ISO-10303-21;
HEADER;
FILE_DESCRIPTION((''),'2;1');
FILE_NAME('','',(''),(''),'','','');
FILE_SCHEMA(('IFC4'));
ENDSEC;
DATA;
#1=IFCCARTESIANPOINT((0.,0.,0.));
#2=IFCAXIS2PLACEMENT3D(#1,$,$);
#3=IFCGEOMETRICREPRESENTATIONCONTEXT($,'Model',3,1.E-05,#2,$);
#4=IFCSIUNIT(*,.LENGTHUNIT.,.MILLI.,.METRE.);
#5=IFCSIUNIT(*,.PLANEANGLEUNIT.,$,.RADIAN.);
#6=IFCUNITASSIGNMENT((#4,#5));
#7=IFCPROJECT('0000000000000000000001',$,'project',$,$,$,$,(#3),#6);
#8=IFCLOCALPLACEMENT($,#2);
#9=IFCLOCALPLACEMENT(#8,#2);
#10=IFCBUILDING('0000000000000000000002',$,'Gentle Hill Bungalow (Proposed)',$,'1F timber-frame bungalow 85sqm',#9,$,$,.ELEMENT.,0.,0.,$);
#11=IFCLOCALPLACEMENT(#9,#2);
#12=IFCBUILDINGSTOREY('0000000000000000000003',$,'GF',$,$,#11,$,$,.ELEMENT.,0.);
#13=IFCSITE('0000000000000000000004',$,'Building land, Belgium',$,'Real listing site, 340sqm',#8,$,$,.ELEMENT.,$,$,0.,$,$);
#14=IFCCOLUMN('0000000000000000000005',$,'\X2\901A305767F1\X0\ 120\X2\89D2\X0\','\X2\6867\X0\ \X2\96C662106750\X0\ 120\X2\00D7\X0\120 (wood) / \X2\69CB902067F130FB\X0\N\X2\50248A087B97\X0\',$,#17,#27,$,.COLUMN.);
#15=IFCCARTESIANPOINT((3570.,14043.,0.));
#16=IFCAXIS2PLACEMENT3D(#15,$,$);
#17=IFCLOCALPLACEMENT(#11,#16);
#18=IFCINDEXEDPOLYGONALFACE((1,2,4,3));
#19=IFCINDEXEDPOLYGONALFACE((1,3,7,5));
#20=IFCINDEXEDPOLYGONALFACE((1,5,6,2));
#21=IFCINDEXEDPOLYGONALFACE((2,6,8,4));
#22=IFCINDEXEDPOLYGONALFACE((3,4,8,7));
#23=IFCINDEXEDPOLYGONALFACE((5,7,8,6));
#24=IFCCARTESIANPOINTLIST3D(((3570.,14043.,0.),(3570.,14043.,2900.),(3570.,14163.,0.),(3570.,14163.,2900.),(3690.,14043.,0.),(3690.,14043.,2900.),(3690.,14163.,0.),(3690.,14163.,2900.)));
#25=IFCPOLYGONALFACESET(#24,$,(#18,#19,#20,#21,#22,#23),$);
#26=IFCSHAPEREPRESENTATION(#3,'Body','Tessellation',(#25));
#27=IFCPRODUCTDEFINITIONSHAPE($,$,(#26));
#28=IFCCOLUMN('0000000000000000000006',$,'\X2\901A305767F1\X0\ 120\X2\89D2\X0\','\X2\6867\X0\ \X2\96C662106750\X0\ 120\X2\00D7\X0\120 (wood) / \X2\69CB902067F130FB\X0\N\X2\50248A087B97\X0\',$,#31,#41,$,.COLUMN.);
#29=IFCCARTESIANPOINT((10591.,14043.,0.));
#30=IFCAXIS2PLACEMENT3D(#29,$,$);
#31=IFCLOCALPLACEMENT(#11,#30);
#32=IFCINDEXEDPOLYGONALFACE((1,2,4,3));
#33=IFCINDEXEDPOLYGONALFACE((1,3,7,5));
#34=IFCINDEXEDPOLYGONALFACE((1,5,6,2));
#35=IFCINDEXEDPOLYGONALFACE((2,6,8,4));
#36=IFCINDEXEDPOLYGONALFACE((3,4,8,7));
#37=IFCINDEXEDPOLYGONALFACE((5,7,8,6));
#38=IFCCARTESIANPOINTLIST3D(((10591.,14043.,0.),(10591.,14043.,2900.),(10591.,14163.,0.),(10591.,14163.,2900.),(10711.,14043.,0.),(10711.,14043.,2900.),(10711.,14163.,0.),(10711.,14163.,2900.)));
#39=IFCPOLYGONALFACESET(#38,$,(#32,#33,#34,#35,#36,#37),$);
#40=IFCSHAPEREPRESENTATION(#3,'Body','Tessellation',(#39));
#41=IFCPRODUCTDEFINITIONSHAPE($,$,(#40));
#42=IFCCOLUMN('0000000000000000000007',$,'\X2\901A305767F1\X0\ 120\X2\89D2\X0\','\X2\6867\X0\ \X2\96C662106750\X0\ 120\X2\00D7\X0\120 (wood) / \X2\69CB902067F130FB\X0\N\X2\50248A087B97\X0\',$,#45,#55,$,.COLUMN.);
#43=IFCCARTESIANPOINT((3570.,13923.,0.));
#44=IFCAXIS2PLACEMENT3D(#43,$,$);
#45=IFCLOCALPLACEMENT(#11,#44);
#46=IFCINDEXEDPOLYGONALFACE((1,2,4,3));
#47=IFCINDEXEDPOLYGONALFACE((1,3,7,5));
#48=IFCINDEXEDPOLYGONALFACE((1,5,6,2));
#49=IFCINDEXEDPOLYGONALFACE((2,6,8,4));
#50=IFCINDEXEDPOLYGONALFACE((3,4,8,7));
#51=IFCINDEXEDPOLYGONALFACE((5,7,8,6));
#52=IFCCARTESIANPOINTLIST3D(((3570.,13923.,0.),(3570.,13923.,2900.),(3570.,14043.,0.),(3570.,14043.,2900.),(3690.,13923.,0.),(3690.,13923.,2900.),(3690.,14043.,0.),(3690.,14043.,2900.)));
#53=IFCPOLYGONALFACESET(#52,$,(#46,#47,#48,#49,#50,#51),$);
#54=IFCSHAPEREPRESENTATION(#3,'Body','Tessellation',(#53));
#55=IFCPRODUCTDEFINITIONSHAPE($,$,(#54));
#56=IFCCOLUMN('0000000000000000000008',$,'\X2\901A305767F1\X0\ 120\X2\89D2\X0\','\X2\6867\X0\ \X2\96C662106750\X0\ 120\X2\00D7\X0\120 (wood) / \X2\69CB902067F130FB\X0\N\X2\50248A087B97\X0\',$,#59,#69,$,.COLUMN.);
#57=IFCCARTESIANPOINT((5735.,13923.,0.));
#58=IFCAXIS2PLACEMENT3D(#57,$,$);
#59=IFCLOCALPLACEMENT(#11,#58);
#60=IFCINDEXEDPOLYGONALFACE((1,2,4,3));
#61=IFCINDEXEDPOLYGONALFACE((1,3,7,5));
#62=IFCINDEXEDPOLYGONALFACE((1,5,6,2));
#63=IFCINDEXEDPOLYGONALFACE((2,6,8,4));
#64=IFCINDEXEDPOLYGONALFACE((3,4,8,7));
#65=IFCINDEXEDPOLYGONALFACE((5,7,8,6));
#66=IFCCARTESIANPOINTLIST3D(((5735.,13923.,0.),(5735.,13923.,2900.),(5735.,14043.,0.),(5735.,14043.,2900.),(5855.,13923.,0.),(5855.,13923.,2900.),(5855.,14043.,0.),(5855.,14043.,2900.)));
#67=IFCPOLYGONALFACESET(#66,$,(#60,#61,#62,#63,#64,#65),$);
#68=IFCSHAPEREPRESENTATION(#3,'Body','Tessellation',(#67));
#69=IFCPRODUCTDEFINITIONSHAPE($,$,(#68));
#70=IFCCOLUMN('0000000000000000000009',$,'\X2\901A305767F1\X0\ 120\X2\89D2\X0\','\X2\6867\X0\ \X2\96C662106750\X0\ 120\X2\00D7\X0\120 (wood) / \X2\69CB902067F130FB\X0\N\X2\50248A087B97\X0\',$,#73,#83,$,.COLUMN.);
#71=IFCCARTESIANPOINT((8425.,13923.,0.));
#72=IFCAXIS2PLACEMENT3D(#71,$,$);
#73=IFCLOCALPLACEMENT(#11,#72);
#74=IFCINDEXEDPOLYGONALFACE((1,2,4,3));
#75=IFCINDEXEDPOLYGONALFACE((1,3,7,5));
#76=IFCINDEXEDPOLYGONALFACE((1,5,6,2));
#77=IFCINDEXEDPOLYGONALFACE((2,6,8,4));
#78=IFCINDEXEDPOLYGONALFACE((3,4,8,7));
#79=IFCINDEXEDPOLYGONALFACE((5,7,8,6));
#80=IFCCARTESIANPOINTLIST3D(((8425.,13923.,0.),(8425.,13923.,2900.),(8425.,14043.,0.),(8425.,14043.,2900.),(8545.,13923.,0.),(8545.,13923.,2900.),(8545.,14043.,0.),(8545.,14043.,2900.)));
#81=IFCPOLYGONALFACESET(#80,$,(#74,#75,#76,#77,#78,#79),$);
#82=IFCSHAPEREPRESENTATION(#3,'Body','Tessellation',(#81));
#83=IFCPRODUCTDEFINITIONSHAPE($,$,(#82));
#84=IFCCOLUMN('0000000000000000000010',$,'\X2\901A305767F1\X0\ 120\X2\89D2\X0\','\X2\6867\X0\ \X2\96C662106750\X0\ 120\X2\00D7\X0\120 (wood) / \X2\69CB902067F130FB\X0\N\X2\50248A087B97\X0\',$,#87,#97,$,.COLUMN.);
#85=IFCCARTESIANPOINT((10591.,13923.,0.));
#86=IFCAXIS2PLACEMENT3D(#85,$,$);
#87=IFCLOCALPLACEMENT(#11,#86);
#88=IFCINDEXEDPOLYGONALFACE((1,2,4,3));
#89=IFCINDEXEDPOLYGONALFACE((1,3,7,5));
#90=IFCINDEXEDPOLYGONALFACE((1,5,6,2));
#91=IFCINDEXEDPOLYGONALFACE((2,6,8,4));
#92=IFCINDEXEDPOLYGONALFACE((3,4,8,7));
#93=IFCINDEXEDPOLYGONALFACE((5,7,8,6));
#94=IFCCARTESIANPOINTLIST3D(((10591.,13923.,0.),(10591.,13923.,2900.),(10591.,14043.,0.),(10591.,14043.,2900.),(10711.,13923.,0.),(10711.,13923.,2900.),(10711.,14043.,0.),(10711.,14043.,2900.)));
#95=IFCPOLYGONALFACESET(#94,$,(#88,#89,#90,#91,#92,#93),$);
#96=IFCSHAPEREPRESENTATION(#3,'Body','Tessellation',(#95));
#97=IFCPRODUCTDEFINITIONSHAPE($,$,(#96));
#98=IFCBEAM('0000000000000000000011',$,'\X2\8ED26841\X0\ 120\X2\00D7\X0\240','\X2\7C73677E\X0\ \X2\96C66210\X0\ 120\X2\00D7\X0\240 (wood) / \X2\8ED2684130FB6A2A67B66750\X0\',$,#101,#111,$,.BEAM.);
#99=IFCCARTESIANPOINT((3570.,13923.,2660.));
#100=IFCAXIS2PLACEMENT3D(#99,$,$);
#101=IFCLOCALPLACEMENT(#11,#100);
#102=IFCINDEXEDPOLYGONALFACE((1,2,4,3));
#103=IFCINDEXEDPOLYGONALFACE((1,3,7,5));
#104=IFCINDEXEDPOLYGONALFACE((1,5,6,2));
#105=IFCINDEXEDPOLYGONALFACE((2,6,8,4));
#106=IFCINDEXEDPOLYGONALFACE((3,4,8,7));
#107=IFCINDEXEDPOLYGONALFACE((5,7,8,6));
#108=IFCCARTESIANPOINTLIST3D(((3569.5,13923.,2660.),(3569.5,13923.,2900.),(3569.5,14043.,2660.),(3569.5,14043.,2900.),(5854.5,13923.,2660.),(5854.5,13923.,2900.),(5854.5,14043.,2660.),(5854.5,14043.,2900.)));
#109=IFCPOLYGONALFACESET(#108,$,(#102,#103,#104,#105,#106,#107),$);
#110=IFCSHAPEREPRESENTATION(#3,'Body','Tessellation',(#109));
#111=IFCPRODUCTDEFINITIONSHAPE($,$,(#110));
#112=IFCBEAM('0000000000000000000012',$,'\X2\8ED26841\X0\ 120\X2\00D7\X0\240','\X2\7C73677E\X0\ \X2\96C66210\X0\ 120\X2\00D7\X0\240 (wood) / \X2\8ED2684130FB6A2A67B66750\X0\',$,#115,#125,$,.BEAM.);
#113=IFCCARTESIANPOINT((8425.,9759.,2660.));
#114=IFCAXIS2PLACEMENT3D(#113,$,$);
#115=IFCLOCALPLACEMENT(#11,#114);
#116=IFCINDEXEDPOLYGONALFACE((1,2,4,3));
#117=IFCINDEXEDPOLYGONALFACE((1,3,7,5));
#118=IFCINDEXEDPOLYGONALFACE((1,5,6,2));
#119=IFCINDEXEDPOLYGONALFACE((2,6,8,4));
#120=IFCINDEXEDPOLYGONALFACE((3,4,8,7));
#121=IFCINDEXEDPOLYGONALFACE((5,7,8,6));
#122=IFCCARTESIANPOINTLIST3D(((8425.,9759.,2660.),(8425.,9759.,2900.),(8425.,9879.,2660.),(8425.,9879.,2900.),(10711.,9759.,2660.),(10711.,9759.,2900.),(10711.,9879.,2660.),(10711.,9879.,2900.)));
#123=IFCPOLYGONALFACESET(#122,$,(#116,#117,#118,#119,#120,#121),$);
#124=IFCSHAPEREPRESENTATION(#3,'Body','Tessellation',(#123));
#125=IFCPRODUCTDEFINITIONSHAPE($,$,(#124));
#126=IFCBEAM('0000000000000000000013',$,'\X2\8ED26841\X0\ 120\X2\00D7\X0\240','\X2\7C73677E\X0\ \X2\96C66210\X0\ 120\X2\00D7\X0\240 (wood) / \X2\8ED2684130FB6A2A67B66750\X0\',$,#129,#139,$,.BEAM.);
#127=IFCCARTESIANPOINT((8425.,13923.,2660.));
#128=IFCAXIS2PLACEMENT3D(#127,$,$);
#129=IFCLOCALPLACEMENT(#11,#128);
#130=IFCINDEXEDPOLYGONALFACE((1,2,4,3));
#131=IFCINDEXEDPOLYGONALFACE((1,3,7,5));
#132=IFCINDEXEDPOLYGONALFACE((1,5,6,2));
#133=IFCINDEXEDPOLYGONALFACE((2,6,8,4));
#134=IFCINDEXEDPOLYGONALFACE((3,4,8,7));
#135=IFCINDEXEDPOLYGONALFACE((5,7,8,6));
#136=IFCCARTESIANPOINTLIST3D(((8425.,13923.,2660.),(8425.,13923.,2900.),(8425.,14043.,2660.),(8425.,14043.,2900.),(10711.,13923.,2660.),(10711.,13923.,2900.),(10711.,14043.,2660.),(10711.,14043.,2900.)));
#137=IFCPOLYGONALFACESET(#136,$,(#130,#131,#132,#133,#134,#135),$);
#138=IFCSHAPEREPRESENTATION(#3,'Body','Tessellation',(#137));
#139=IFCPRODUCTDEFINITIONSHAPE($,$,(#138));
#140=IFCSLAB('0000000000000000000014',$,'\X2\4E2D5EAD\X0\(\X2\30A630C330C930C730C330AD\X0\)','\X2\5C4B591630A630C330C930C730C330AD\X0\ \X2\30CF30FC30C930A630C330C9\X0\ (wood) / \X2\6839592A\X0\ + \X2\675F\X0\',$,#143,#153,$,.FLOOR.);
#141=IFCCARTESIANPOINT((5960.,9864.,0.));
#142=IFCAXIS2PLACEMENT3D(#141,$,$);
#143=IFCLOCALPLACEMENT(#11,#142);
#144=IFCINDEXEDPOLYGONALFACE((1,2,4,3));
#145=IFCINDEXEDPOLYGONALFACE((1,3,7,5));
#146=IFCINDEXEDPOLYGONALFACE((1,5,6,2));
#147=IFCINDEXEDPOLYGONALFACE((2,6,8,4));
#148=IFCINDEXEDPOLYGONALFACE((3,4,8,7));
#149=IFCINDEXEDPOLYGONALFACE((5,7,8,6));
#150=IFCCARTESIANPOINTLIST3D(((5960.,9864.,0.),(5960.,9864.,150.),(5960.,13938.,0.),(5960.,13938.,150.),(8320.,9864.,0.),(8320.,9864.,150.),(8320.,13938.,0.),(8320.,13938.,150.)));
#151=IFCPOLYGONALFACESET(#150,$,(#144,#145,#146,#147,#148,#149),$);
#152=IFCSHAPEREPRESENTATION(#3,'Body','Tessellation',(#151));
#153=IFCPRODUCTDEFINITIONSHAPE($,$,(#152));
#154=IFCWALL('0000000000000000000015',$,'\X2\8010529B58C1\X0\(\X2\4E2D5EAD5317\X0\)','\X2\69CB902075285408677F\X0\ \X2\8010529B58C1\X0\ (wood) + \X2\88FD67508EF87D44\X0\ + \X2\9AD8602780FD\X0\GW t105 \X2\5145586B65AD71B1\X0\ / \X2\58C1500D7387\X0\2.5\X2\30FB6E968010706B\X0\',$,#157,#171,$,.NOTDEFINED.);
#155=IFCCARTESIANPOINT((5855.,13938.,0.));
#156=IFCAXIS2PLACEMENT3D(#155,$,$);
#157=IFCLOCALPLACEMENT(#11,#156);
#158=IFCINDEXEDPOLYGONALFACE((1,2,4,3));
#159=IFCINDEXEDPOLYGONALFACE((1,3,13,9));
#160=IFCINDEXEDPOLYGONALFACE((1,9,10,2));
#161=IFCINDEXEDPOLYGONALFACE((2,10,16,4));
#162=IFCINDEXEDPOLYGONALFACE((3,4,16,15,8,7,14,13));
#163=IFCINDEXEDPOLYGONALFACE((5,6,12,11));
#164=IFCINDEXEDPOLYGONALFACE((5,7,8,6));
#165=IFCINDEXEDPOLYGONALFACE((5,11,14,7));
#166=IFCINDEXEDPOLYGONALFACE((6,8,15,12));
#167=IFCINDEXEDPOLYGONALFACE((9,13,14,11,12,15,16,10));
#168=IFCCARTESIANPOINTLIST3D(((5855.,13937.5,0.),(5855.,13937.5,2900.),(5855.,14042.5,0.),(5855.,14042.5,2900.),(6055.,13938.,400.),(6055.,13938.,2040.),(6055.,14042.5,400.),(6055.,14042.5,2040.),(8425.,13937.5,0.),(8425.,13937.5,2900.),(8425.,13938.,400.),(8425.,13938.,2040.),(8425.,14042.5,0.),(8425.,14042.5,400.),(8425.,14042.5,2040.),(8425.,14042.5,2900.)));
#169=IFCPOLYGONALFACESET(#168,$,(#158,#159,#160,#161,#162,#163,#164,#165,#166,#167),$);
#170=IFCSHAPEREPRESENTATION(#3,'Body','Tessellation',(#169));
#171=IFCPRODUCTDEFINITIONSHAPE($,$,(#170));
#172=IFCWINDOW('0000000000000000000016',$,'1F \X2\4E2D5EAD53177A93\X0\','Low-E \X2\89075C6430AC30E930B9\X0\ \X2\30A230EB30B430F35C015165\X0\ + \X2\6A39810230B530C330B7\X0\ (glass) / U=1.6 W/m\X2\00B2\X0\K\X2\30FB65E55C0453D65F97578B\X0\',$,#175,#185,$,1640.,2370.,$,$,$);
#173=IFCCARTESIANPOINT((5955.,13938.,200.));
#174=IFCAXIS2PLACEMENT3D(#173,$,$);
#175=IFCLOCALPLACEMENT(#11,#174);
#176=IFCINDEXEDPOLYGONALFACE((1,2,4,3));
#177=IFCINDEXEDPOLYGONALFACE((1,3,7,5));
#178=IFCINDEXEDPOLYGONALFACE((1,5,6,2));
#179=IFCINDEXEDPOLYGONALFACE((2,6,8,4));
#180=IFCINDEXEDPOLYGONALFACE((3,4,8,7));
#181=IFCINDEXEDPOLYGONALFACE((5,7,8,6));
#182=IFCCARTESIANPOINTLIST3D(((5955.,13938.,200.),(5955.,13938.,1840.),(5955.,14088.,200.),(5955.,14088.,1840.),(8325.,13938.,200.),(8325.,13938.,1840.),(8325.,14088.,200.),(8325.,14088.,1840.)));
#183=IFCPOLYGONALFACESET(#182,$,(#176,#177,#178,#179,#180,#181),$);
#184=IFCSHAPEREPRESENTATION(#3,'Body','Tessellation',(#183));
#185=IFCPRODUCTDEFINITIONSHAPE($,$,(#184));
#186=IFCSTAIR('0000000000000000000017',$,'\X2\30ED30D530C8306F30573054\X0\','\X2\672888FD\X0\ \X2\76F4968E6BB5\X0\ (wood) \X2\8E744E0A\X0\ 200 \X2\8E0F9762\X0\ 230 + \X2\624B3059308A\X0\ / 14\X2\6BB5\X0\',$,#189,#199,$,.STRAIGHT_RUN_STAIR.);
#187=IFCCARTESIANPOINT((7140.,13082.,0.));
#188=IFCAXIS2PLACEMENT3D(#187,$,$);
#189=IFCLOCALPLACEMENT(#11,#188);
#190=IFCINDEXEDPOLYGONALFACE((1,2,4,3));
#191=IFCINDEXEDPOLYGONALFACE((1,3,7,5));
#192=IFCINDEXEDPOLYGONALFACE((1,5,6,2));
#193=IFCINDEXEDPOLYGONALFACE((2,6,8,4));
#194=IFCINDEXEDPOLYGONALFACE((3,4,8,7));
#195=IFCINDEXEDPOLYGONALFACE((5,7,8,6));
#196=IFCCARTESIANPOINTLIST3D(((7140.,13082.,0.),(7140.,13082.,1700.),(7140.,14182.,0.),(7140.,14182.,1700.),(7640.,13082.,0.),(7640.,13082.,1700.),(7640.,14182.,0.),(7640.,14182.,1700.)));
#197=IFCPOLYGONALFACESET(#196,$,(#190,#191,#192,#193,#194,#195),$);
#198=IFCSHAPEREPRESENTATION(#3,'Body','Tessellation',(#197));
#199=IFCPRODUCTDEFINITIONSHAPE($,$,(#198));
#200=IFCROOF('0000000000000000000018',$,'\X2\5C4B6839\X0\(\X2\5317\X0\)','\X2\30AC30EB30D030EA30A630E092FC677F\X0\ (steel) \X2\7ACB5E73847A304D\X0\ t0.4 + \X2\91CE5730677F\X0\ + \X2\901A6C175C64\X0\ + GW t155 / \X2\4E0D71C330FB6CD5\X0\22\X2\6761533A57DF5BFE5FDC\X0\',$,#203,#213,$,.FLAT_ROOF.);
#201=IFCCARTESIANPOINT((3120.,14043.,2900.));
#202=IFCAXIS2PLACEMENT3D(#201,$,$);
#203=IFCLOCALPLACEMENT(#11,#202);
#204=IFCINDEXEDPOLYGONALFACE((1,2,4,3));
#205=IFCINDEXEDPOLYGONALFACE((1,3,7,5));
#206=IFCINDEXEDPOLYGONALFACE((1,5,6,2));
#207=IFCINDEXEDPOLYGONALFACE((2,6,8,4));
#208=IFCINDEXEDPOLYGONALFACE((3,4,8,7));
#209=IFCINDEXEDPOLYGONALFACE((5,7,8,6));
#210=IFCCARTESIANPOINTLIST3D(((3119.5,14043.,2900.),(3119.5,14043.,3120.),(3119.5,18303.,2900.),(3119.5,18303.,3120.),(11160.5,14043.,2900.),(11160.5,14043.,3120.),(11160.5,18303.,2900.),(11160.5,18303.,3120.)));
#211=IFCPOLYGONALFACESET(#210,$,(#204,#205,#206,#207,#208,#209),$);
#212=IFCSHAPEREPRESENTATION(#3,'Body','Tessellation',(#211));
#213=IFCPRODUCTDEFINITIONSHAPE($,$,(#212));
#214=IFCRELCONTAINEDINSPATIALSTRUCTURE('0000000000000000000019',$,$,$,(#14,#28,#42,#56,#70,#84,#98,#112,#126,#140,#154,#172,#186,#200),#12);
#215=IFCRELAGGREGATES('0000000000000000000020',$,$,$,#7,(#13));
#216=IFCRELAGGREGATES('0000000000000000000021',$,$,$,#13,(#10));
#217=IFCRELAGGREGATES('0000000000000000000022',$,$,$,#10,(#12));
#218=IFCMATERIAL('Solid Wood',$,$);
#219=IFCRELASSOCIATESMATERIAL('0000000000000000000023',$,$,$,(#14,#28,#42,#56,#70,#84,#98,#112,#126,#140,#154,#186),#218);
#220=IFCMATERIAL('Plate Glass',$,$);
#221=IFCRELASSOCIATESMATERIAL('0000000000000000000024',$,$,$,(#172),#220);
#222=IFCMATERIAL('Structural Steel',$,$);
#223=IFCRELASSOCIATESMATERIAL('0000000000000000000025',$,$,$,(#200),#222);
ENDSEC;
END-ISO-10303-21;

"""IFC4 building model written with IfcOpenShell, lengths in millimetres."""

from ifc_helpers import new_model, si_unit, frame, frame_2d, origin, place, context, project, spatial, rectangle, extrude, material, element, fill, save


model = new_model("IFC4")

# Units and contexts
model_context = context("Model", 3, precision=1e-05, world=origin())
ifc_project = project(units=[si_unit("LENGTHUNIT", "METRE", prefix="MILLI"), si_unit("PLANEANGLEUNIT", "RADIAN")], contexts=[model_context])

# Site, building, storey
site_placement = place(None, origin())
site = spatial("IfcSite", under=ifc_project, at=site_placement, Name="Building land, Belgium", ObjectType="Real listing site, 340sqm", CompositionType="ELEMENT", RefElevation=0.0)
building_placement = place(site_placement, origin())
building = spatial("IfcBuilding", under=site, at=building_placement, Name="Gentle Hill Bungalow (Proposed)", ObjectType="1F timber-frame bungalow 85sqm", CompositionType="ELEMENT", ElevationOfRefHeight=0.0, ElevationOfTerrain=0.0)
storey_placement = place(building_placement, origin())
storey = spatial("IfcBuildingStorey", under=building, at=storey_placement, Name="GF", CompositionType="ELEMENT", Elevation=0.0)

# Columns
ifc_material_1 = material(Name="Solid Wood")
column_1_placement = place(storey_placement, frame((3570.0, 14043.0, 0.0)))
element("IfcColumn", 1, at=column_1_placement, inside=storey, material=ifc_material_1, Name="通し柱 120角", Description="桧 集成材 120×120 (wood) / 構造柱・N値計算", PredefinedType="COLUMN", context=model_context, shape_type="SweptSolid", body=[
    extrude(rectangle(XDim=120.0, YDim=120.0, at=frame_2d((60.0, 60.0))), frame((3570.0, 14043.0, 0.0)), (0.0, 0.0, 1.0), 2900.0),
])
column_2_placement = place(storey_placement, frame((10591.0, 14043.0, 0.0)))
element("IfcColumn", 2, at=column_2_placement, inside=storey, material=ifc_material_1, Name="通し柱 120角", Description="桧 集成材 120×120 (wood) / 構造柱・N値計算", PredefinedType="COLUMN", context=model_context, shape_type="SweptSolid", body=[
    extrude(rectangle(XDim=120.0, YDim=120.0, at=frame_2d((60.0, 60.0))), frame((10591.0, 14043.0, 0.0)), (0.0, 0.0, 1.0), 2900.0),
])
column_3_placement = place(storey_placement, frame((3570.0, 13923.0, 0.0)))
element("IfcColumn", 3, at=column_3_placement, inside=storey, material=ifc_material_1, Name="通し柱 120角", Description="桧 集成材 120×120 (wood) / 構造柱・N値計算", PredefinedType="COLUMN", context=model_context, shape_type="SweptSolid", body=[
    extrude(rectangle(XDim=120.0, YDim=120.0, at=frame_2d((60.0, 60.0))), frame((3570.0, 13923.0, 0.0)), (0.0, 0.0, 1.0), 2900.0),
])
column_4_placement = place(storey_placement, frame((5735.0, 13923.0, 0.0)))
element("IfcColumn", 4, at=column_4_placement, inside=storey, material=ifc_material_1, Name="通し柱 120角", Description="桧 集成材 120×120 (wood) / 構造柱・N値計算", PredefinedType="COLUMN", context=model_context, shape_type="SweptSolid", body=[
    extrude(rectangle(XDim=120.0, YDim=120.0, at=frame_2d((60.0, 60.0))), frame((5735.0, 13923.0, 0.0)), (0.0, 0.0, 1.0), 2900.0),
])
column_5_placement = place(storey_placement, frame((8425.0, 13923.0, 0.0)))
element("IfcColumn", 5, at=column_5_placement, inside=storey, material=ifc_material_1, Name="通し柱 120角", Description="桧 集成材 120×120 (wood) / 構造柱・N値計算", PredefinedType="COLUMN", context=model_context, shape_type="SweptSolid", body=[
    extrude(rectangle(XDim=120.0, YDim=120.0, at=frame_2d((60.0, 60.0))), frame((8425.0, 13923.0, 0.0)), (0.0, 0.0, 1.0), 2900.0),
])
column_6_placement = place(storey_placement, frame((10591.0, 13923.0, 0.0)))
element("IfcColumn", 6, at=column_6_placement, inside=storey, material=ifc_material_1, Name="通し柱 120角", Description="桧 集成材 120×120 (wood) / 構造柱・N値計算", PredefinedType="COLUMN", context=model_context, shape_type="SweptSolid", body=[
    extrude(rectangle(XDim=120.0, YDim=120.0, at=frame_2d((60.0, 60.0))), frame((10591.0, 13923.0, 0.0)), (0.0, 0.0, 1.0), 2900.0),
])

# Beams
beam_1_placement = place(storey_placement, frame((3570.0, 13923.0, 2660.0)))
element("IfcBeam", 7, at=beam_1_placement, inside=storey, material=ifc_material_1, Name="軒桁 120×240", Description="米松 集成 120×240 (wood) / 軒桁・横架材", PredefinedType="BEAM", context=model_context, shape_type="SweptSolid", body=[
    extrude(rectangle(XDim=2285.0, YDim=120.0, at=frame_2d((1142.0, 60.0))), frame((3570.0, 13923.0, 2660.0)), (0.0, 0.0, 1.0), 240.0),
])
beam_2_placement = place(storey_placement, frame((8425.0, 9759.0, 2660.0)))
element("IfcBeam", 8, at=beam_2_placement, inside=storey, material=ifc_material_1, Name="軒桁 120×240", Description="米松 集成 120×240 (wood) / 軒桁・横架材", PredefinedType="BEAM", context=model_context, shape_type="SweptSolid", body=[
    extrude(rectangle(XDim=2286.0, YDim=120.0, at=frame_2d((1143.0, 60.0))), frame((8425.0, 9759.0, 2660.0)), (0.0, 0.0, 1.0), 240.0),
])
beam_3_placement = place(storey_placement, frame((8425.0, 13923.0, 2660.0)))
element("IfcBeam", 9, at=beam_3_placement, inside=storey, material=ifc_material_1, Name="軒桁 120×240", Description="米松 集成 120×240 (wood) / 軒桁・横架材", PredefinedType="BEAM", context=model_context, shape_type="SweptSolid", body=[
    extrude(rectangle(XDim=2286.0, YDim=120.0, at=frame_2d((1143.0, 60.0))), frame((8425.0, 13923.0, 2660.0)), (0.0, 0.0, 1.0), 240.0),
])

# Slab
slab_1_placement = place(storey_placement, frame((5960.0, 9864.0, 0.0)))
element("IfcSlab", 10, at=slab_1_placement, inside=storey, material=ifc_material_1, Name="中庭(ウッドデッキ)", Description="屋外ウッドデッキ ハードウッド (wood) / 根太 + 束", PredefinedType="FLOOR", context=model_context, shape_type="SweptSolid", body=[
    extrude(rectangle(XDim=2360.0, YDim=4074.0, at=frame_2d((1180.0, 2037.0))), frame((5960.0, 9864.0, 0.0)), (0.0, 0.0, 1.0), 150.0),
])

# Wall, opening, window
wall_placement = place(storey_placement, frame((5855.0, 13938.0, 0.0)))
wall = element("IfcWall", 11, at=wall_placement, inside=storey, material=ifc_material_1, Name="耐力壁(中庭北)", Description="構造用合板 耐力壁 (wood) + 製材軸組 + 高性能GW t105 充填断熱 / 壁倍率2.5・準耐火", PredefinedType="NOTDEFINED", context=model_context, shape_type="SweptSolid", body=[
    extrude(rectangle(XDim=2570.0, YDim=105.0, at=frame_2d((1285.0, 52.0))), frame((5855.0, 13938.0, 0.0)), (0.0, 0.0, 1.0), 2900.0),
])
opening_placement = place(storey_placement, frame((5955.0, 13938.0, 200.0)))
opening = element("IfcOpeningElement", 12, at=opening_placement, cuts=wall, PredefinedType="NOTDEFINED", context=model_context, shape_type="SweptSolid", body=[
    extrude(rectangle(XDim=2370.0, YDim=150.0, at=frame_2d((1185.0, 75.0))), frame((5955.0, 13938.0, 200.0)), (0.0, 0.0, 1.0), 1640.0),
])
ifc_material_2 = material(Name="Plate Glass")
window_placement = place(storey_placement, frame((5955.0, 13938.0, 200.0)))
window = element("IfcWindow", 13, at=window_placement, inside=storey, material=ifc_material_2, Name="1F 中庭北窓", Description="Low-E 複層ガラス アルゴン封入 + 樹脂サッシ (glass) / U=1.6 W/m²K・日射取得型", OverallHeight=1640.0, OverallWidth=2370.0, context=model_context, shape_type="SweptSolid", body=[
    extrude(rectangle(XDim=2370.0, YDim=150.0, at=frame_2d((1185.0, 75.0))), frame((5955.0, 13938.0, 200.0)), (0.0, 0.0, 1.0), 1640.0),
])
fill(opening, window)

# Stair
stair_placement = place(storey_placement, frame((7140.0, 13082.0, 0.0)))
element("IfcStair", 14, at=stair_placement, inside=storey, material=ifc_material_1, Name="ロフトはしご", Description="木製 直階段 (wood) 蹴上 200 踏面 230 + 手すり / 14段", PredefinedType="STRAIGHT_RUN_STAIR", context=model_context, shape_type="SweptSolid", body=[
    extrude(rectangle(XDim=500.0, YDim=1100.0, at=frame_2d((250.0, 550.0))), frame((7140.0, 13082.0, 0.0)), (0.0, 0.0, 1.0), 1700.0),
])

# Roof
ifc_material_3 = material(Name="Structural Steel")
roof_placement = place(storey_placement, frame((3120.0, 14043.0, 2900.0)))
element("IfcRoof", 15, at=roof_placement, inside=storey, material=ifc_material_3, Name="屋根(北)", Description="ガルバリウム鋼板 (steel) 立平葺き t0.4 + 野地板 + 通気層 + GW t155 / 不燃・法22条区域対応", PredefinedType="FLAT_ROOF", context=model_context, shape_type="SweptSolid", body=[
    extrude(rectangle(XDim=8041.0, YDim=4260.0, at=frame_2d((4020.0, 2130.0))), frame((3120.0, 14043.0, 2900.0)), (0.0, 0.0, 1.0), 220.0),
])

save(model, "model.ifc")
